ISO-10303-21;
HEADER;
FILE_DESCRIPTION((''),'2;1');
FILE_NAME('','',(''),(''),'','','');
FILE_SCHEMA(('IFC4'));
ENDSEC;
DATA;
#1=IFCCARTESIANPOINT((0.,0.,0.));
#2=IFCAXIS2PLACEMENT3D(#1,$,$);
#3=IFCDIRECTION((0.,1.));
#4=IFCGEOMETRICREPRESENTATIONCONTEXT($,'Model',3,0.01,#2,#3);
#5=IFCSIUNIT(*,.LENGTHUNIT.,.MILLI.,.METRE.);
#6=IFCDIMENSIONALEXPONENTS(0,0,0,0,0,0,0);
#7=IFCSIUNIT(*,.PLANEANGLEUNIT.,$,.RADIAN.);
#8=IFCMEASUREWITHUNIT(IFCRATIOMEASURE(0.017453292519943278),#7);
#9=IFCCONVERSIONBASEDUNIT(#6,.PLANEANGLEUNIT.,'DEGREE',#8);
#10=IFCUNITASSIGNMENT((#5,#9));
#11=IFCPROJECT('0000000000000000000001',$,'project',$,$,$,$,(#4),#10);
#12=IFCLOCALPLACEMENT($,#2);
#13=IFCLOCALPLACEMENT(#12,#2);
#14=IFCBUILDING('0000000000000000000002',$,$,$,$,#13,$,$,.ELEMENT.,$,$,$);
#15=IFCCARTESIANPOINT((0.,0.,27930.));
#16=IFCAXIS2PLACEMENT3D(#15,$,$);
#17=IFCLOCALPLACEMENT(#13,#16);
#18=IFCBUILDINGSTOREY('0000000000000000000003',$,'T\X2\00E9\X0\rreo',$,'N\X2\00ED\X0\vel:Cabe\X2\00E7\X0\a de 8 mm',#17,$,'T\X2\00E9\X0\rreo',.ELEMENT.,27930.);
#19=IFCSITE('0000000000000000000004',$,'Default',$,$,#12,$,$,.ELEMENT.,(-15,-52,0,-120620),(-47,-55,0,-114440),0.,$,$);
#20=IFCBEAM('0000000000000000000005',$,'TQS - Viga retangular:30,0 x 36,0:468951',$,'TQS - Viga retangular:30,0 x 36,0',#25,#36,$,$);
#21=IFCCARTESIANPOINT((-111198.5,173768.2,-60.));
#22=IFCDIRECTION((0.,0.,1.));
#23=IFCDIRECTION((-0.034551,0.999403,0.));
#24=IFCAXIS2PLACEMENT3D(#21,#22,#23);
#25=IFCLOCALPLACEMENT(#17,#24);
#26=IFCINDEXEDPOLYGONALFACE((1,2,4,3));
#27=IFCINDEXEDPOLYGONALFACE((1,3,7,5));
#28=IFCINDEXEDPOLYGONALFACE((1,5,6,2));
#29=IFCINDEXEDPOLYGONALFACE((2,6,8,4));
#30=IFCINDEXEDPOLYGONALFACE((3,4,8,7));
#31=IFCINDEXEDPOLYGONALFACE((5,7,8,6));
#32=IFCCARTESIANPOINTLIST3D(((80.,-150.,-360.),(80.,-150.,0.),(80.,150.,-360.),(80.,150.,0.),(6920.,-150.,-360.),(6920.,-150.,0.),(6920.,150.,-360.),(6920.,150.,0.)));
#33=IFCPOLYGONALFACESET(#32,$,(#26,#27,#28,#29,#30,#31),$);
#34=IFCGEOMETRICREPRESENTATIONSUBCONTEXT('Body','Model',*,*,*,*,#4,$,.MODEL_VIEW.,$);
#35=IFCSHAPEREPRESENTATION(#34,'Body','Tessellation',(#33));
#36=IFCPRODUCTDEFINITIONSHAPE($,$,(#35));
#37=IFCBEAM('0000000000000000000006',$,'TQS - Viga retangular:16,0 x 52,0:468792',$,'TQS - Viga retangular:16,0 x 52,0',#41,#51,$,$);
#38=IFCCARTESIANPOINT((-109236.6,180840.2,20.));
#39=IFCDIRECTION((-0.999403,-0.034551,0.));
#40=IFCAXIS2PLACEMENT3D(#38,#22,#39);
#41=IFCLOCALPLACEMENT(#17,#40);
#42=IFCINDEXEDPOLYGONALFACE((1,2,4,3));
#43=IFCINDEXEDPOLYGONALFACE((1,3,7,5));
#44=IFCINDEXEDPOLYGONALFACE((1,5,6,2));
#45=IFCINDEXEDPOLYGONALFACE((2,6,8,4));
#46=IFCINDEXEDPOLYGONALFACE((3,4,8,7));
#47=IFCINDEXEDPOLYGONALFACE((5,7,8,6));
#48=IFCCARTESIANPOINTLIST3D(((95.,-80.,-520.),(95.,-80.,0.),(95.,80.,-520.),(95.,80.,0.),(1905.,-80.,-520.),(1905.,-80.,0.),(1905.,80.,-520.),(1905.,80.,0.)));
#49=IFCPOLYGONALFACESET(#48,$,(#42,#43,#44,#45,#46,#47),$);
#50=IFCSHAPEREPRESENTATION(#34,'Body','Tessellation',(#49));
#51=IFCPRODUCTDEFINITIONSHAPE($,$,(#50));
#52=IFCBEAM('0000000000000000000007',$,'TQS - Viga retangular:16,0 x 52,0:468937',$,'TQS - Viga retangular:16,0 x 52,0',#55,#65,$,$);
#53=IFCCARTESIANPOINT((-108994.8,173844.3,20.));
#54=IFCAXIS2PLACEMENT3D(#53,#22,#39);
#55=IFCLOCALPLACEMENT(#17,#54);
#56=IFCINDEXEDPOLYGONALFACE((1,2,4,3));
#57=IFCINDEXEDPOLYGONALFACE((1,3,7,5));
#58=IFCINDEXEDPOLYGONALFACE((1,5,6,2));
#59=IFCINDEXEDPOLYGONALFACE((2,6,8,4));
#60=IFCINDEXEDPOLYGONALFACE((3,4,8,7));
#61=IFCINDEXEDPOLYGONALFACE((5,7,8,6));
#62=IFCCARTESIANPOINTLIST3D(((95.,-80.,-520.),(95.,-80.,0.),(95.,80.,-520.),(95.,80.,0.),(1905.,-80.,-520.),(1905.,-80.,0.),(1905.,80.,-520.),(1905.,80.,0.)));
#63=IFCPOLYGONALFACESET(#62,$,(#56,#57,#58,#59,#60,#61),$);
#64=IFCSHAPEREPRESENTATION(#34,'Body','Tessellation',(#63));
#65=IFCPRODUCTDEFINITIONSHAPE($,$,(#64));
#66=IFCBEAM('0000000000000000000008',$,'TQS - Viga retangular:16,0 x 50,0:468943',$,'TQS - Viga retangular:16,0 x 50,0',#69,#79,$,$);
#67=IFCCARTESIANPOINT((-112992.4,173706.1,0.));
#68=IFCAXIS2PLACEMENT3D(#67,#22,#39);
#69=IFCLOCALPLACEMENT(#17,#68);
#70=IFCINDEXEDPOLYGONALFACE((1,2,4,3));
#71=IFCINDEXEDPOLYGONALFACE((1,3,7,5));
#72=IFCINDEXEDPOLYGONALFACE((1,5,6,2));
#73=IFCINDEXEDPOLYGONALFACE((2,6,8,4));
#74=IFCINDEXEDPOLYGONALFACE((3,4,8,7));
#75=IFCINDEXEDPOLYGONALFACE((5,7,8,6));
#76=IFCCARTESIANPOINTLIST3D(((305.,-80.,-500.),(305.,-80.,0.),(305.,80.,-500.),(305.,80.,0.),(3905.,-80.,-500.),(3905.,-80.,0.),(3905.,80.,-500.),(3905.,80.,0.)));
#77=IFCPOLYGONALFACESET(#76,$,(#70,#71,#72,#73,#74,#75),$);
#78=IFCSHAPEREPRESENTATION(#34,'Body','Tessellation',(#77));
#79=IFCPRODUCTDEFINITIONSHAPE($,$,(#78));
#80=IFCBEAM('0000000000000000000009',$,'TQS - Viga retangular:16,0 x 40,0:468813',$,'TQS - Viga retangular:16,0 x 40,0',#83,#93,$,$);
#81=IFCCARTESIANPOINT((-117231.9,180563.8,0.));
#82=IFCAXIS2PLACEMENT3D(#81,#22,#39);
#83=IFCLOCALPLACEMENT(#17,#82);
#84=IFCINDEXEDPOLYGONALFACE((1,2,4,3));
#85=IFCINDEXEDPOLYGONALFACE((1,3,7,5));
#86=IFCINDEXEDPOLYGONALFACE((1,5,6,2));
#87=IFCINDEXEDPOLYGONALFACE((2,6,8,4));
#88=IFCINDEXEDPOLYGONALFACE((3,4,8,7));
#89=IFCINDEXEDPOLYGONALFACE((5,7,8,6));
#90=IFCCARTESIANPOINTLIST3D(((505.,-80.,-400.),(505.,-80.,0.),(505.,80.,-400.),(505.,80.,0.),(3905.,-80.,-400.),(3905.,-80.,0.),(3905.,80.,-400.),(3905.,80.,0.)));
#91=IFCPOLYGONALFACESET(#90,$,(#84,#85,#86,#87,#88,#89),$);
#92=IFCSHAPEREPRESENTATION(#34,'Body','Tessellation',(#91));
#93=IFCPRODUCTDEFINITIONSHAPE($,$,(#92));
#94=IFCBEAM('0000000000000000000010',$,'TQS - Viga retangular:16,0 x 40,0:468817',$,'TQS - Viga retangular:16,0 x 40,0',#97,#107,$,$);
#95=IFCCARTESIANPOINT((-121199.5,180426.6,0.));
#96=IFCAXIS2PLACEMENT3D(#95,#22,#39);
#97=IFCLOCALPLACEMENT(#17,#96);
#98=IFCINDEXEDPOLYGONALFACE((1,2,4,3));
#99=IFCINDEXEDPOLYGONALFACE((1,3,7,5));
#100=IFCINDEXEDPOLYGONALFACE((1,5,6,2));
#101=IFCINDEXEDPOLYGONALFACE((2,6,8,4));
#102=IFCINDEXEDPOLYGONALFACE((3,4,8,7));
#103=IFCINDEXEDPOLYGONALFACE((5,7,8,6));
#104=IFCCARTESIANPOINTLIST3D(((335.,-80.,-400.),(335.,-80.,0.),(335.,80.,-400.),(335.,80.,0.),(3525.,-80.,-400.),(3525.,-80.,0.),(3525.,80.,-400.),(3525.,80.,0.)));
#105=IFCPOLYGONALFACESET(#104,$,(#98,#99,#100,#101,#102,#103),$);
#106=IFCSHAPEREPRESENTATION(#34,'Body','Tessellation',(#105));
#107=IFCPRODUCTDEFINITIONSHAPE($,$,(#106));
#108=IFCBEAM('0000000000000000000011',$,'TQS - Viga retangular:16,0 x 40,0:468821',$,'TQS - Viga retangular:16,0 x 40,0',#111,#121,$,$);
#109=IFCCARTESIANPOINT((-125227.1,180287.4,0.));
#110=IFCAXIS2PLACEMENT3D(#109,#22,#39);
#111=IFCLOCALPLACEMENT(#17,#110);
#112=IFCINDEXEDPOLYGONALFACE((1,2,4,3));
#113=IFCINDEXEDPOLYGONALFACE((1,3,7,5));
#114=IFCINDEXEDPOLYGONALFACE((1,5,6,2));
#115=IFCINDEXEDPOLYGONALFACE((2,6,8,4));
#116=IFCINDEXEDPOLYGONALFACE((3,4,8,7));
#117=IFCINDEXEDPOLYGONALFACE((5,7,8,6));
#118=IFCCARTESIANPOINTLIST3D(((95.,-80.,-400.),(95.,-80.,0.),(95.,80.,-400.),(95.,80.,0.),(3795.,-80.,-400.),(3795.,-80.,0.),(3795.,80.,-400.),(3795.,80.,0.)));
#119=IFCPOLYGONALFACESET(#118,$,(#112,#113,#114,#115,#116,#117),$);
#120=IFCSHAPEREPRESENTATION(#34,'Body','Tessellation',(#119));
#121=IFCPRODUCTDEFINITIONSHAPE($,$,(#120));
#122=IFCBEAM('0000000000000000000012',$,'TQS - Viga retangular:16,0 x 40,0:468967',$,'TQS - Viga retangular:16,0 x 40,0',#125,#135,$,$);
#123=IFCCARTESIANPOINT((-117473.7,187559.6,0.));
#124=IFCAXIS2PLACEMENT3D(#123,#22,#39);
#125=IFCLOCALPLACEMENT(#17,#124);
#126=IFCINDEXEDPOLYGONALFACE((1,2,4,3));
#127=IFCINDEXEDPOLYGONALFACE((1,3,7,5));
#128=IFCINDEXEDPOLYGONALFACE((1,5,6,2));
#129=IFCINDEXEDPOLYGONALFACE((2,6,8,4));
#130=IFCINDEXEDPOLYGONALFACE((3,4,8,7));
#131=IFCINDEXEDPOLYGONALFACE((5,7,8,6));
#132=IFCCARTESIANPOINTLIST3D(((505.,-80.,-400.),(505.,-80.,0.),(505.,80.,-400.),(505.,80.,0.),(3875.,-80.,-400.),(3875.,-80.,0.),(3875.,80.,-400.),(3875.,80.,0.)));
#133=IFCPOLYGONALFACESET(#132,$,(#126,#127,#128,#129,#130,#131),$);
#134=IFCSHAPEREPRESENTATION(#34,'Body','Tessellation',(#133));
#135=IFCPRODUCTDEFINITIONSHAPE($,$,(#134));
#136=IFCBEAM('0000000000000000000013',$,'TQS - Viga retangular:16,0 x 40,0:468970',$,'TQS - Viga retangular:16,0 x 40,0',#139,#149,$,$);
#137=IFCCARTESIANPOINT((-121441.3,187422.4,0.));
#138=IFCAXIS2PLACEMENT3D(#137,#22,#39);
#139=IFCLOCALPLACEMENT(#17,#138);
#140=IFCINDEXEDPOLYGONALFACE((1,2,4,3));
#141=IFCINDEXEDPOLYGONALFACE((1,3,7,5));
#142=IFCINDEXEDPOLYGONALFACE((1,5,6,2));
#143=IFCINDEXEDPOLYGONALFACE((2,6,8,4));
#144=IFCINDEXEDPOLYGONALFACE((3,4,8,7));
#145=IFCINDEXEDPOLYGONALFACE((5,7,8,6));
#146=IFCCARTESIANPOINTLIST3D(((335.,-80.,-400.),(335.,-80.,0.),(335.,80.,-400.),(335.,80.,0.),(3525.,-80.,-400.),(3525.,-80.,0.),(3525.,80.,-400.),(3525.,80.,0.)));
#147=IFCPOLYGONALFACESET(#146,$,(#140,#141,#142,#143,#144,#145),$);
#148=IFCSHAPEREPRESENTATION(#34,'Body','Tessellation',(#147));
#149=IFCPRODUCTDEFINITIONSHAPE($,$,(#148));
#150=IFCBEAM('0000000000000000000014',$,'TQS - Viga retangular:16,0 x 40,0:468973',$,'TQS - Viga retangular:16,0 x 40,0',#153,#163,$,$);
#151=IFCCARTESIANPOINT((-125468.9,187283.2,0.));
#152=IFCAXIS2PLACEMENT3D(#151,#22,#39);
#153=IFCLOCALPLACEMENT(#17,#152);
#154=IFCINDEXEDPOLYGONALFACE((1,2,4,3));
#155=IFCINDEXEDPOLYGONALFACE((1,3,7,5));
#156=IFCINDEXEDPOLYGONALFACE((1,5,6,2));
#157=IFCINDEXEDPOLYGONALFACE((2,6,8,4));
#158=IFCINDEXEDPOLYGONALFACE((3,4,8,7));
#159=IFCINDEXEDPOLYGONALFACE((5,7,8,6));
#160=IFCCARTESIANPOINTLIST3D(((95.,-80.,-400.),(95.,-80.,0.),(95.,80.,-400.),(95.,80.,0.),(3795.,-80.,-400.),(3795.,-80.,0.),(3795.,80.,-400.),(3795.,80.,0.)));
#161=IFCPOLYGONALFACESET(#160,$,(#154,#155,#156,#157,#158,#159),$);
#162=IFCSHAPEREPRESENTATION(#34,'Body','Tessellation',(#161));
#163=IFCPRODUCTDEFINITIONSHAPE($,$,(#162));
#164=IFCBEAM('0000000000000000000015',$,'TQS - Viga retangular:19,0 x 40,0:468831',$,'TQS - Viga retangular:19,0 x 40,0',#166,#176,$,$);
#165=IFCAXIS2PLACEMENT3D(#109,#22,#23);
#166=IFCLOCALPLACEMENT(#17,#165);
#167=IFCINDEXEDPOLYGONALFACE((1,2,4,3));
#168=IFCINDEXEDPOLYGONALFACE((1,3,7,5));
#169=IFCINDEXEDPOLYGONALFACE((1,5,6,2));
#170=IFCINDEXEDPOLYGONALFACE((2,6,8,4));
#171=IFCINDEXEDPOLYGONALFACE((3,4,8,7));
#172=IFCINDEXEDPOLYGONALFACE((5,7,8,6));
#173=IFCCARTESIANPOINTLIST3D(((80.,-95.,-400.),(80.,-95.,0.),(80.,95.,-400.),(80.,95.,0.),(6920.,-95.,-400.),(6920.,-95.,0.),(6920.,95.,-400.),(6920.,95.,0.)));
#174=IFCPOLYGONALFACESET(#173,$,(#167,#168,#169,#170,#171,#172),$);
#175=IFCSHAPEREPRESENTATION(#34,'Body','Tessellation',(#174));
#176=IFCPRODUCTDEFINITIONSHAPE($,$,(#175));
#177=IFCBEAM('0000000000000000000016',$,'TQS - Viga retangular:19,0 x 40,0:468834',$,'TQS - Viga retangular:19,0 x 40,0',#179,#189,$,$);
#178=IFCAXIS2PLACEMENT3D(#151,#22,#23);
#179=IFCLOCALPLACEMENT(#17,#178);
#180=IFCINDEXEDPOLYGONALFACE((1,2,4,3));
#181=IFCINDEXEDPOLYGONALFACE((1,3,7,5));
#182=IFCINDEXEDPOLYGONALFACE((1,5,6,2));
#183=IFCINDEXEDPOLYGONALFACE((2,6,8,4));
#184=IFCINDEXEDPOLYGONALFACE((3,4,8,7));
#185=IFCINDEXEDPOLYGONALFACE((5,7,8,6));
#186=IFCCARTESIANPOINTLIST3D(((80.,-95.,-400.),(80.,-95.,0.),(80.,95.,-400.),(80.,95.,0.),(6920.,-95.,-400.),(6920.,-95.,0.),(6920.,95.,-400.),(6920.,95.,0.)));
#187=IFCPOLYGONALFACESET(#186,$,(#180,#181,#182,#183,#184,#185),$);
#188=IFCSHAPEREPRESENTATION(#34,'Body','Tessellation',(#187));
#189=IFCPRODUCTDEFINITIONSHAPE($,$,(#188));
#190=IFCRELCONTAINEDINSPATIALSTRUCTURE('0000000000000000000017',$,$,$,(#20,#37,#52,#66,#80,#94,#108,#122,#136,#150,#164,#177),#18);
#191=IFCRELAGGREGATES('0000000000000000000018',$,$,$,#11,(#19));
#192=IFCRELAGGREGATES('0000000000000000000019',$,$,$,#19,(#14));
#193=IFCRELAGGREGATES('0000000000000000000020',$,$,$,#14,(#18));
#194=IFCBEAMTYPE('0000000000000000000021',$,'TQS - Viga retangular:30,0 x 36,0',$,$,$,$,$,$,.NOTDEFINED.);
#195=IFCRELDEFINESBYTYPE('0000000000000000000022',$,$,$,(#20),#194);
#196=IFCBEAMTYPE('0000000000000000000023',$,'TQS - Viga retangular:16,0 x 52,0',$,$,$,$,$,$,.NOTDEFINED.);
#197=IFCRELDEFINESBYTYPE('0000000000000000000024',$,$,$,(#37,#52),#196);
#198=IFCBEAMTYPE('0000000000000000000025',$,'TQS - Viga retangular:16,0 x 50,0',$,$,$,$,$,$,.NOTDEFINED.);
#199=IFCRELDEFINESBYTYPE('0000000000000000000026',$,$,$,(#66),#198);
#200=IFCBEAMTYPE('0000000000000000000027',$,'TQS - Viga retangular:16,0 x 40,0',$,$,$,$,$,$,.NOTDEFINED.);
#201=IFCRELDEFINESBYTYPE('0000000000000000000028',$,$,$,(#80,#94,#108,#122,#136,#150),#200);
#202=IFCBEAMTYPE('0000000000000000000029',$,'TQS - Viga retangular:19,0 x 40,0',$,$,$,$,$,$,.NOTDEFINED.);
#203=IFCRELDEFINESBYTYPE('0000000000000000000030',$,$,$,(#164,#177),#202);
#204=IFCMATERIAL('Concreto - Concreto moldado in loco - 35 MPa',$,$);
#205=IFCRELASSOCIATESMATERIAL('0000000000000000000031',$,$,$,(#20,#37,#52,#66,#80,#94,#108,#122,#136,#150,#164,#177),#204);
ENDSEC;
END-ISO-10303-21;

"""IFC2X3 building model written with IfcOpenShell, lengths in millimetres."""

from ifc_helpers import new_model, entity, si_unit, converted_unit, direction, frame, frame_2d, origin, origin_2d_with_axis, place, context, subcontext, project, spatial, rectangle, extrude, material, type_object, element, save


model = new_model("IFC2X3")

# Units and contexts
model_context = context("Model", 3, precision=0.01, world=origin(), true_north=direction((0.0, 1.0)))
body_context = subcontext(model_context, "Body", "Model", "MODEL_VIEW")
ifc_project = project(units=[si_unit("LENGTHUNIT", "METRE", prefix="MILLI"), converted_unit("PLANEANGLEUNIT", "DEGREE", entity("IfcRatioMeasure", 0.017453292519943278), si_unit("PLANEANGLEUNIT", "RADIAN"), dimensions=[0, 0, 0, 0, 0, 0, 0])], contexts=[model_context])

# Site, building, storey
site_placement = place(None, origin())
site = spatial("IfcSite", under=ifc_project, at=site_placement, Name="Default", CompositionType="ELEMENT", RefLatitude=(-15, -52, 0, -120620), RefLongitude=(-47, -55, 0, -114440), RefElevation=0.0)
building_placement = place(site_placement, origin())
building = spatial("IfcBuilding", under=site, at=building_placement, CompositionType="ELEMENT")
storey_placement = place(building_placement, frame((0.0, 0.0, 27930.0)))
storey = spatial("IfcBuildingStorey", under=building, at=storey_placement, Name="Térreo", ObjectType="Nível:Cabeça de 8 mm", LongName="Térreo", CompositionType="ELEMENT", Elevation=27930.0)

# Beams
ifc_material_1 = material(Name="Concreto - Concreto moldado in loco - 35 MPa")
beam_type_1 = type_object("IfcBeamType", Name="TQS - Viga retangular:30,0 x 36,0", PredefinedType="NOTDEFINED")
beam_1_placement = place(storey_placement, frame((-111198.5, 173768.2, -60.0), z_axis=(0.0, 0.0, 1.0), x_axis=(-0.034551, 0.999403, 0.0)))
element("IfcBeam", 1, at=beam_1_placement, inside=storey, type_object=beam_type_1, material=ifc_material_1, Name="TQS - Viga retangular:30,0 x 36,0:468951", ObjectType="TQS - Viga retangular:30,0 x 36,0", context=body_context, shape_type="SweptSolid", body=[
    extrude(rectangle(XDim=360.0, YDim=300.0, at=frame_2d((0.0, 0.0), x_axis=(1.0, 0.0))), frame((80.0, 0.0, -180.0), z_axis=(1.0, 0.0, 0.0), x_axis=(0.0, 0.0, -1.0)), (0.0, 0.0, 1.0), 6840.0),
])
beam_type_2 = type_object("IfcBeamType", Name="TQS - Viga retangular:16,0 x 52,0", PredefinedType="NOTDEFINED")
beam_2_placement = place(storey_placement, frame((-109236.6, 180840.2, 20.0), z_axis=(0.0, 0.0, 1.0), x_axis=(-0.999403, -0.034551, 0.0)))
element("IfcBeam", 2, at=beam_2_placement, inside=storey, type_object=beam_type_2, material=ifc_material_1, Name="TQS - Viga retangular:16,0 x 52,0:468792", ObjectType="TQS - Viga retangular:16,0 x 52,0", context=body_context, shape_type="SweptSolid", body=[
    extrude(rectangle(XDim=520.0, YDim=160.0, at=frame_2d((0.0, 0.0), x_axis=(1.0, 0.0))), frame((95.0, 0.0, -260.0), z_axis=(1.0, 0.0, 0.0), x_axis=(0.0, 0.0, -1.0)), (0.0, 0.0, 1.0), 1810.0),
])
beam_3_placement = place(storey_placement, frame((-108994.8, 173844.3, 20.0), z_axis=(0.0, 0.0, 1.0), x_axis=(-0.999403, -0.034551, 0.0)))
element("IfcBeam", 3, at=beam_3_placement, inside=storey, type_object=beam_type_2, material=ifc_material_1, Name="TQS - Viga retangular:16,0 x 52,0:468937", ObjectType="TQS - Viga retangular:16,0 x 52,0", context=body_context, shape_type="SweptSolid", body=[
    extrude(rectangle(XDim=520.0, YDim=160.0, at=frame_2d((0.0, 0.0), x_axis=(1.0, 0.0))), frame((95.0, 0.0, -260.0), z_axis=(1.0, 0.0, 0.0), x_axis=(0.0, 0.0, -1.0)), (0.0, 0.0, 1.0), 1810.0),
])
beam_type_3 = type_object("IfcBeamType", Name="TQS - Viga retangular:16,0 x 50,0", PredefinedType="NOTDEFINED")
beam_4_placement = place(storey_placement, frame((-112992.4, 173706.1, 0.0), z_axis=(0.0, 0.0, 1.0), x_axis=(-0.999403, -0.034551, 0.0)))
element("IfcBeam", 4, at=beam_4_placement, inside=storey, type_object=beam_type_3, material=ifc_material_1, Name="TQS - Viga retangular:16,0 x 50,0:468943", ObjectType="TQS - Viga retangular:16,0 x 50,0", context=body_context, shape_type="SweptSolid", body=[
    extrude(rectangle(XDim=500.0, YDim=160.0, at=origin_2d_with_axis()), frame((305.0, 0.0, -250.0), z_axis=(1.0, 0.0, 0.0), x_axis=(0.0, 0.0, -1.0)), (0.0, 0.0, 1.0), 3600.0),
])
beam_type_4 = type_object("IfcBeamType", Name="TQS - Viga retangular:16,0 x 40,0", PredefinedType="NOTDEFINED")
beam_5_placement = place(storey_placement, frame((-117231.9, 180563.8, 0.0), z_axis=(0.0, 0.0, 1.0), x_axis=(-0.999403, -0.034551, 0.0)))
element("IfcBeam", 5, at=beam_5_placement, inside=storey, type_object=beam_type_4, material=ifc_material_1, Name="TQS - Viga retangular:16,0 x 40,0:468813", ObjectType="TQS - Viga retangular:16,0 x 40,0", context=body_context, shape_type="SweptSolid", body=[
    extrude(rectangle(XDim=400.0, YDim=160.0, at=frame_2d((0.0, 0.0), x_axis=(1.0, 0.0))), frame((505.0, 0.0, -200.0), z_axis=(1.0, 0.0, 0.0), x_axis=(0.0, 0.0, -1.0)), (0.0, 0.0, 1.0), 3400.0),
])
beam_6_placement = place(storey_placement, frame((-121199.5, 180426.6, 0.0), z_axis=(0.0, 0.0, 1.0), x_axis=(-0.999403, -0.034551, 0.0)))
element("IfcBeam", 6, at=beam_6_placement, inside=storey, type_object=beam_type_4, material=ifc_material_1, Name="TQS - Viga retangular:16,0 x 40,0:468817", ObjectType="TQS - Viga retangular:16,0 x 40,0", context=body_context, shape_type="SweptSolid", body=[
    extrude(rectangle(XDim=400.0, YDim=160.0, at=frame_2d((0.0, 0.0), x_axis=(1.0, 0.0))), frame((335.0, 0.0, -200.0), z_axis=(1.0, 0.0, 0.0), x_axis=(0.0, 0.0, -1.0)), (0.0, 0.0, 1.0), 3190.0),
])
beam_7_placement = place(storey_placement, frame((-125227.1, 180287.4, 0.0), z_axis=(0.0, 0.0, 1.0), x_axis=(-0.999403, -0.034551, 0.0)))
element("IfcBeam", 7, at=beam_7_placement, inside=storey, type_object=beam_type_4, material=ifc_material_1, Name="TQS - Viga retangular:16,0 x 40,0:468821", ObjectType="TQS - Viga retangular:16,0 x 40,0", context=body_context, shape_type="SweptSolid", body=[
    extrude(rectangle(XDim=400.0, YDim=160.0, at=frame_2d((0.0, 0.0), x_axis=(1.0, 0.0))), frame((95.0, 0.0, -200.0), z_axis=(1.0, 0.0, 0.0), x_axis=(0.0, 0.0, -1.0)), (0.0, 0.0, 1.0), 3700.0),
])
beam_8_placement = place(storey_placement, frame((-117473.7, 187559.6, 0.0), z_axis=(0.0, 0.0, 1.0), x_axis=(-0.999403, -0.034551, 0.0)))
element("IfcBeam", 8, at=beam_8_placement, inside=storey, type_object=beam_type_4, material=ifc_material_1, Name="TQS - Viga retangular:16,0 x 40,0:468967", ObjectType="TQS - Viga retangular:16,0 x 40,0", context=body_context, shape_type="SweptSolid", body=[
    extrude(rectangle(XDim=400.0, YDim=160.0, at=frame_2d((0.0, 0.0), x_axis=(1.0, 0.0))), frame((505.0, 0.0, -200.0), z_axis=(1.0, 0.0, 0.0), x_axis=(0.0, 0.0, -1.0)), (0.0, 0.0, 1.0), 3370.0),
])
beam_9_placement = place(storey_placement, frame((-121441.3, 187422.4, 0.0), z_axis=(0.0, 0.0, 1.0), x_axis=(-0.999403, -0.034551, 0.0)))
element("IfcBeam", 9, at=beam_9_placement, inside=storey, type_object=beam_type_4, material=ifc_material_1, Name="TQS - Viga retangular:16,0 x 40,0:468970", ObjectType="TQS - Viga retangular:16,0 x 40,0", context=body_context, shape_type="SweptSolid", body=[
    extrude(rectangle(XDim=400.0, YDim=160.0, at=frame_2d((0.0, 0.0), x_axis=(1.0, 0.0))), frame((335.0, 0.0, -200.0), z_axis=(1.0, 0.0, 0.0), x_axis=(0.0, 0.0, -1.0)), (0.0, 0.0, 1.0), 3190.0),
])
beam_10_placement = place(storey_placement, frame((-125468.9, 187283.2, 0.0), z_axis=(0.0, 0.0, 1.0), x_axis=(-0.999403, -0.034551, 0.0)))
element("IfcBeam", 10, at=beam_10_placement, inside=storey, type_object=beam_type_4, material=ifc_material_1, Name="TQS - Viga retangular:16,0 x 40,0:468973", ObjectType="TQS - Viga retangular:16,0 x 40,0", context=body_context, shape_type="SweptSolid", body=[
    extrude(rectangle(XDim=400.0, YDim=160.0, at=frame_2d((0.0, 0.0), x_axis=(1.0, 0.0))), frame((95.0, 0.0, -200.0), z_axis=(1.0, 0.0, 0.0), x_axis=(0.0, 0.0, -1.0)), (0.0, 0.0, 1.0), 3700.0),
])
beam_type_5 = type_object("IfcBeamType", Name="TQS - Viga retangular:19,0 x 40,0", PredefinedType="NOTDEFINED")
beam_11_placement = place(storey_placement, frame((-125227.1, 180287.4, 0.0), z_axis=(0.0, 0.0, 1.0), x_axis=(-0.034551, 0.999403, 0.0)))
element("IfcBeam", 11, at=beam_11_placement, inside=storey, type_object=beam_type_5, material=ifc_material_1, Name="TQS - Viga retangular:19,0 x 40,0:468831", ObjectType="TQS - Viga retangular:19,0 x 40,0", context=body_context, shape_type="SweptSolid", body=[
    extrude(rectangle(XDim=400.0, YDim=190.0, at=frame_2d((0.0, 0.0), x_axis=(1.0, 0.0))), frame((80.0, 0.0, -200.0), z_axis=(1.0, 0.0, 0.0), x_axis=(0.0, 0.0, -1.0)), (0.0, 0.0, 1.0), 6840.0),
])
beam_12_placement = place(storey_placement, frame((-125468.9, 187283.2, 0.0), z_axis=(0.0, 0.0, 1.0), x_axis=(-0.034551, 0.999403, 0.0)))
element("IfcBeam", 12, at=beam_12_placement, inside=storey, type_object=beam_type_5, material=ifc_material_1, Name="TQS - Viga retangular:19,0 x 40,0:468834", ObjectType="TQS - Viga retangular:19,0 x 40,0", context=body_context, shape_type="SweptSolid", body=[
    extrude(rectangle(XDim=400.0, YDim=190.0, at=frame_2d((0.0, 0.0), x_axis=(1.0, 0.0))), frame((80.0, 0.0, -200.0), z_axis=(1.0, 0.0, 0.0), x_axis=(0.0, 0.0, -1.0)), (0.0, 0.0, 1.0), 6840.0),
])

save(model, "model.ifc")
